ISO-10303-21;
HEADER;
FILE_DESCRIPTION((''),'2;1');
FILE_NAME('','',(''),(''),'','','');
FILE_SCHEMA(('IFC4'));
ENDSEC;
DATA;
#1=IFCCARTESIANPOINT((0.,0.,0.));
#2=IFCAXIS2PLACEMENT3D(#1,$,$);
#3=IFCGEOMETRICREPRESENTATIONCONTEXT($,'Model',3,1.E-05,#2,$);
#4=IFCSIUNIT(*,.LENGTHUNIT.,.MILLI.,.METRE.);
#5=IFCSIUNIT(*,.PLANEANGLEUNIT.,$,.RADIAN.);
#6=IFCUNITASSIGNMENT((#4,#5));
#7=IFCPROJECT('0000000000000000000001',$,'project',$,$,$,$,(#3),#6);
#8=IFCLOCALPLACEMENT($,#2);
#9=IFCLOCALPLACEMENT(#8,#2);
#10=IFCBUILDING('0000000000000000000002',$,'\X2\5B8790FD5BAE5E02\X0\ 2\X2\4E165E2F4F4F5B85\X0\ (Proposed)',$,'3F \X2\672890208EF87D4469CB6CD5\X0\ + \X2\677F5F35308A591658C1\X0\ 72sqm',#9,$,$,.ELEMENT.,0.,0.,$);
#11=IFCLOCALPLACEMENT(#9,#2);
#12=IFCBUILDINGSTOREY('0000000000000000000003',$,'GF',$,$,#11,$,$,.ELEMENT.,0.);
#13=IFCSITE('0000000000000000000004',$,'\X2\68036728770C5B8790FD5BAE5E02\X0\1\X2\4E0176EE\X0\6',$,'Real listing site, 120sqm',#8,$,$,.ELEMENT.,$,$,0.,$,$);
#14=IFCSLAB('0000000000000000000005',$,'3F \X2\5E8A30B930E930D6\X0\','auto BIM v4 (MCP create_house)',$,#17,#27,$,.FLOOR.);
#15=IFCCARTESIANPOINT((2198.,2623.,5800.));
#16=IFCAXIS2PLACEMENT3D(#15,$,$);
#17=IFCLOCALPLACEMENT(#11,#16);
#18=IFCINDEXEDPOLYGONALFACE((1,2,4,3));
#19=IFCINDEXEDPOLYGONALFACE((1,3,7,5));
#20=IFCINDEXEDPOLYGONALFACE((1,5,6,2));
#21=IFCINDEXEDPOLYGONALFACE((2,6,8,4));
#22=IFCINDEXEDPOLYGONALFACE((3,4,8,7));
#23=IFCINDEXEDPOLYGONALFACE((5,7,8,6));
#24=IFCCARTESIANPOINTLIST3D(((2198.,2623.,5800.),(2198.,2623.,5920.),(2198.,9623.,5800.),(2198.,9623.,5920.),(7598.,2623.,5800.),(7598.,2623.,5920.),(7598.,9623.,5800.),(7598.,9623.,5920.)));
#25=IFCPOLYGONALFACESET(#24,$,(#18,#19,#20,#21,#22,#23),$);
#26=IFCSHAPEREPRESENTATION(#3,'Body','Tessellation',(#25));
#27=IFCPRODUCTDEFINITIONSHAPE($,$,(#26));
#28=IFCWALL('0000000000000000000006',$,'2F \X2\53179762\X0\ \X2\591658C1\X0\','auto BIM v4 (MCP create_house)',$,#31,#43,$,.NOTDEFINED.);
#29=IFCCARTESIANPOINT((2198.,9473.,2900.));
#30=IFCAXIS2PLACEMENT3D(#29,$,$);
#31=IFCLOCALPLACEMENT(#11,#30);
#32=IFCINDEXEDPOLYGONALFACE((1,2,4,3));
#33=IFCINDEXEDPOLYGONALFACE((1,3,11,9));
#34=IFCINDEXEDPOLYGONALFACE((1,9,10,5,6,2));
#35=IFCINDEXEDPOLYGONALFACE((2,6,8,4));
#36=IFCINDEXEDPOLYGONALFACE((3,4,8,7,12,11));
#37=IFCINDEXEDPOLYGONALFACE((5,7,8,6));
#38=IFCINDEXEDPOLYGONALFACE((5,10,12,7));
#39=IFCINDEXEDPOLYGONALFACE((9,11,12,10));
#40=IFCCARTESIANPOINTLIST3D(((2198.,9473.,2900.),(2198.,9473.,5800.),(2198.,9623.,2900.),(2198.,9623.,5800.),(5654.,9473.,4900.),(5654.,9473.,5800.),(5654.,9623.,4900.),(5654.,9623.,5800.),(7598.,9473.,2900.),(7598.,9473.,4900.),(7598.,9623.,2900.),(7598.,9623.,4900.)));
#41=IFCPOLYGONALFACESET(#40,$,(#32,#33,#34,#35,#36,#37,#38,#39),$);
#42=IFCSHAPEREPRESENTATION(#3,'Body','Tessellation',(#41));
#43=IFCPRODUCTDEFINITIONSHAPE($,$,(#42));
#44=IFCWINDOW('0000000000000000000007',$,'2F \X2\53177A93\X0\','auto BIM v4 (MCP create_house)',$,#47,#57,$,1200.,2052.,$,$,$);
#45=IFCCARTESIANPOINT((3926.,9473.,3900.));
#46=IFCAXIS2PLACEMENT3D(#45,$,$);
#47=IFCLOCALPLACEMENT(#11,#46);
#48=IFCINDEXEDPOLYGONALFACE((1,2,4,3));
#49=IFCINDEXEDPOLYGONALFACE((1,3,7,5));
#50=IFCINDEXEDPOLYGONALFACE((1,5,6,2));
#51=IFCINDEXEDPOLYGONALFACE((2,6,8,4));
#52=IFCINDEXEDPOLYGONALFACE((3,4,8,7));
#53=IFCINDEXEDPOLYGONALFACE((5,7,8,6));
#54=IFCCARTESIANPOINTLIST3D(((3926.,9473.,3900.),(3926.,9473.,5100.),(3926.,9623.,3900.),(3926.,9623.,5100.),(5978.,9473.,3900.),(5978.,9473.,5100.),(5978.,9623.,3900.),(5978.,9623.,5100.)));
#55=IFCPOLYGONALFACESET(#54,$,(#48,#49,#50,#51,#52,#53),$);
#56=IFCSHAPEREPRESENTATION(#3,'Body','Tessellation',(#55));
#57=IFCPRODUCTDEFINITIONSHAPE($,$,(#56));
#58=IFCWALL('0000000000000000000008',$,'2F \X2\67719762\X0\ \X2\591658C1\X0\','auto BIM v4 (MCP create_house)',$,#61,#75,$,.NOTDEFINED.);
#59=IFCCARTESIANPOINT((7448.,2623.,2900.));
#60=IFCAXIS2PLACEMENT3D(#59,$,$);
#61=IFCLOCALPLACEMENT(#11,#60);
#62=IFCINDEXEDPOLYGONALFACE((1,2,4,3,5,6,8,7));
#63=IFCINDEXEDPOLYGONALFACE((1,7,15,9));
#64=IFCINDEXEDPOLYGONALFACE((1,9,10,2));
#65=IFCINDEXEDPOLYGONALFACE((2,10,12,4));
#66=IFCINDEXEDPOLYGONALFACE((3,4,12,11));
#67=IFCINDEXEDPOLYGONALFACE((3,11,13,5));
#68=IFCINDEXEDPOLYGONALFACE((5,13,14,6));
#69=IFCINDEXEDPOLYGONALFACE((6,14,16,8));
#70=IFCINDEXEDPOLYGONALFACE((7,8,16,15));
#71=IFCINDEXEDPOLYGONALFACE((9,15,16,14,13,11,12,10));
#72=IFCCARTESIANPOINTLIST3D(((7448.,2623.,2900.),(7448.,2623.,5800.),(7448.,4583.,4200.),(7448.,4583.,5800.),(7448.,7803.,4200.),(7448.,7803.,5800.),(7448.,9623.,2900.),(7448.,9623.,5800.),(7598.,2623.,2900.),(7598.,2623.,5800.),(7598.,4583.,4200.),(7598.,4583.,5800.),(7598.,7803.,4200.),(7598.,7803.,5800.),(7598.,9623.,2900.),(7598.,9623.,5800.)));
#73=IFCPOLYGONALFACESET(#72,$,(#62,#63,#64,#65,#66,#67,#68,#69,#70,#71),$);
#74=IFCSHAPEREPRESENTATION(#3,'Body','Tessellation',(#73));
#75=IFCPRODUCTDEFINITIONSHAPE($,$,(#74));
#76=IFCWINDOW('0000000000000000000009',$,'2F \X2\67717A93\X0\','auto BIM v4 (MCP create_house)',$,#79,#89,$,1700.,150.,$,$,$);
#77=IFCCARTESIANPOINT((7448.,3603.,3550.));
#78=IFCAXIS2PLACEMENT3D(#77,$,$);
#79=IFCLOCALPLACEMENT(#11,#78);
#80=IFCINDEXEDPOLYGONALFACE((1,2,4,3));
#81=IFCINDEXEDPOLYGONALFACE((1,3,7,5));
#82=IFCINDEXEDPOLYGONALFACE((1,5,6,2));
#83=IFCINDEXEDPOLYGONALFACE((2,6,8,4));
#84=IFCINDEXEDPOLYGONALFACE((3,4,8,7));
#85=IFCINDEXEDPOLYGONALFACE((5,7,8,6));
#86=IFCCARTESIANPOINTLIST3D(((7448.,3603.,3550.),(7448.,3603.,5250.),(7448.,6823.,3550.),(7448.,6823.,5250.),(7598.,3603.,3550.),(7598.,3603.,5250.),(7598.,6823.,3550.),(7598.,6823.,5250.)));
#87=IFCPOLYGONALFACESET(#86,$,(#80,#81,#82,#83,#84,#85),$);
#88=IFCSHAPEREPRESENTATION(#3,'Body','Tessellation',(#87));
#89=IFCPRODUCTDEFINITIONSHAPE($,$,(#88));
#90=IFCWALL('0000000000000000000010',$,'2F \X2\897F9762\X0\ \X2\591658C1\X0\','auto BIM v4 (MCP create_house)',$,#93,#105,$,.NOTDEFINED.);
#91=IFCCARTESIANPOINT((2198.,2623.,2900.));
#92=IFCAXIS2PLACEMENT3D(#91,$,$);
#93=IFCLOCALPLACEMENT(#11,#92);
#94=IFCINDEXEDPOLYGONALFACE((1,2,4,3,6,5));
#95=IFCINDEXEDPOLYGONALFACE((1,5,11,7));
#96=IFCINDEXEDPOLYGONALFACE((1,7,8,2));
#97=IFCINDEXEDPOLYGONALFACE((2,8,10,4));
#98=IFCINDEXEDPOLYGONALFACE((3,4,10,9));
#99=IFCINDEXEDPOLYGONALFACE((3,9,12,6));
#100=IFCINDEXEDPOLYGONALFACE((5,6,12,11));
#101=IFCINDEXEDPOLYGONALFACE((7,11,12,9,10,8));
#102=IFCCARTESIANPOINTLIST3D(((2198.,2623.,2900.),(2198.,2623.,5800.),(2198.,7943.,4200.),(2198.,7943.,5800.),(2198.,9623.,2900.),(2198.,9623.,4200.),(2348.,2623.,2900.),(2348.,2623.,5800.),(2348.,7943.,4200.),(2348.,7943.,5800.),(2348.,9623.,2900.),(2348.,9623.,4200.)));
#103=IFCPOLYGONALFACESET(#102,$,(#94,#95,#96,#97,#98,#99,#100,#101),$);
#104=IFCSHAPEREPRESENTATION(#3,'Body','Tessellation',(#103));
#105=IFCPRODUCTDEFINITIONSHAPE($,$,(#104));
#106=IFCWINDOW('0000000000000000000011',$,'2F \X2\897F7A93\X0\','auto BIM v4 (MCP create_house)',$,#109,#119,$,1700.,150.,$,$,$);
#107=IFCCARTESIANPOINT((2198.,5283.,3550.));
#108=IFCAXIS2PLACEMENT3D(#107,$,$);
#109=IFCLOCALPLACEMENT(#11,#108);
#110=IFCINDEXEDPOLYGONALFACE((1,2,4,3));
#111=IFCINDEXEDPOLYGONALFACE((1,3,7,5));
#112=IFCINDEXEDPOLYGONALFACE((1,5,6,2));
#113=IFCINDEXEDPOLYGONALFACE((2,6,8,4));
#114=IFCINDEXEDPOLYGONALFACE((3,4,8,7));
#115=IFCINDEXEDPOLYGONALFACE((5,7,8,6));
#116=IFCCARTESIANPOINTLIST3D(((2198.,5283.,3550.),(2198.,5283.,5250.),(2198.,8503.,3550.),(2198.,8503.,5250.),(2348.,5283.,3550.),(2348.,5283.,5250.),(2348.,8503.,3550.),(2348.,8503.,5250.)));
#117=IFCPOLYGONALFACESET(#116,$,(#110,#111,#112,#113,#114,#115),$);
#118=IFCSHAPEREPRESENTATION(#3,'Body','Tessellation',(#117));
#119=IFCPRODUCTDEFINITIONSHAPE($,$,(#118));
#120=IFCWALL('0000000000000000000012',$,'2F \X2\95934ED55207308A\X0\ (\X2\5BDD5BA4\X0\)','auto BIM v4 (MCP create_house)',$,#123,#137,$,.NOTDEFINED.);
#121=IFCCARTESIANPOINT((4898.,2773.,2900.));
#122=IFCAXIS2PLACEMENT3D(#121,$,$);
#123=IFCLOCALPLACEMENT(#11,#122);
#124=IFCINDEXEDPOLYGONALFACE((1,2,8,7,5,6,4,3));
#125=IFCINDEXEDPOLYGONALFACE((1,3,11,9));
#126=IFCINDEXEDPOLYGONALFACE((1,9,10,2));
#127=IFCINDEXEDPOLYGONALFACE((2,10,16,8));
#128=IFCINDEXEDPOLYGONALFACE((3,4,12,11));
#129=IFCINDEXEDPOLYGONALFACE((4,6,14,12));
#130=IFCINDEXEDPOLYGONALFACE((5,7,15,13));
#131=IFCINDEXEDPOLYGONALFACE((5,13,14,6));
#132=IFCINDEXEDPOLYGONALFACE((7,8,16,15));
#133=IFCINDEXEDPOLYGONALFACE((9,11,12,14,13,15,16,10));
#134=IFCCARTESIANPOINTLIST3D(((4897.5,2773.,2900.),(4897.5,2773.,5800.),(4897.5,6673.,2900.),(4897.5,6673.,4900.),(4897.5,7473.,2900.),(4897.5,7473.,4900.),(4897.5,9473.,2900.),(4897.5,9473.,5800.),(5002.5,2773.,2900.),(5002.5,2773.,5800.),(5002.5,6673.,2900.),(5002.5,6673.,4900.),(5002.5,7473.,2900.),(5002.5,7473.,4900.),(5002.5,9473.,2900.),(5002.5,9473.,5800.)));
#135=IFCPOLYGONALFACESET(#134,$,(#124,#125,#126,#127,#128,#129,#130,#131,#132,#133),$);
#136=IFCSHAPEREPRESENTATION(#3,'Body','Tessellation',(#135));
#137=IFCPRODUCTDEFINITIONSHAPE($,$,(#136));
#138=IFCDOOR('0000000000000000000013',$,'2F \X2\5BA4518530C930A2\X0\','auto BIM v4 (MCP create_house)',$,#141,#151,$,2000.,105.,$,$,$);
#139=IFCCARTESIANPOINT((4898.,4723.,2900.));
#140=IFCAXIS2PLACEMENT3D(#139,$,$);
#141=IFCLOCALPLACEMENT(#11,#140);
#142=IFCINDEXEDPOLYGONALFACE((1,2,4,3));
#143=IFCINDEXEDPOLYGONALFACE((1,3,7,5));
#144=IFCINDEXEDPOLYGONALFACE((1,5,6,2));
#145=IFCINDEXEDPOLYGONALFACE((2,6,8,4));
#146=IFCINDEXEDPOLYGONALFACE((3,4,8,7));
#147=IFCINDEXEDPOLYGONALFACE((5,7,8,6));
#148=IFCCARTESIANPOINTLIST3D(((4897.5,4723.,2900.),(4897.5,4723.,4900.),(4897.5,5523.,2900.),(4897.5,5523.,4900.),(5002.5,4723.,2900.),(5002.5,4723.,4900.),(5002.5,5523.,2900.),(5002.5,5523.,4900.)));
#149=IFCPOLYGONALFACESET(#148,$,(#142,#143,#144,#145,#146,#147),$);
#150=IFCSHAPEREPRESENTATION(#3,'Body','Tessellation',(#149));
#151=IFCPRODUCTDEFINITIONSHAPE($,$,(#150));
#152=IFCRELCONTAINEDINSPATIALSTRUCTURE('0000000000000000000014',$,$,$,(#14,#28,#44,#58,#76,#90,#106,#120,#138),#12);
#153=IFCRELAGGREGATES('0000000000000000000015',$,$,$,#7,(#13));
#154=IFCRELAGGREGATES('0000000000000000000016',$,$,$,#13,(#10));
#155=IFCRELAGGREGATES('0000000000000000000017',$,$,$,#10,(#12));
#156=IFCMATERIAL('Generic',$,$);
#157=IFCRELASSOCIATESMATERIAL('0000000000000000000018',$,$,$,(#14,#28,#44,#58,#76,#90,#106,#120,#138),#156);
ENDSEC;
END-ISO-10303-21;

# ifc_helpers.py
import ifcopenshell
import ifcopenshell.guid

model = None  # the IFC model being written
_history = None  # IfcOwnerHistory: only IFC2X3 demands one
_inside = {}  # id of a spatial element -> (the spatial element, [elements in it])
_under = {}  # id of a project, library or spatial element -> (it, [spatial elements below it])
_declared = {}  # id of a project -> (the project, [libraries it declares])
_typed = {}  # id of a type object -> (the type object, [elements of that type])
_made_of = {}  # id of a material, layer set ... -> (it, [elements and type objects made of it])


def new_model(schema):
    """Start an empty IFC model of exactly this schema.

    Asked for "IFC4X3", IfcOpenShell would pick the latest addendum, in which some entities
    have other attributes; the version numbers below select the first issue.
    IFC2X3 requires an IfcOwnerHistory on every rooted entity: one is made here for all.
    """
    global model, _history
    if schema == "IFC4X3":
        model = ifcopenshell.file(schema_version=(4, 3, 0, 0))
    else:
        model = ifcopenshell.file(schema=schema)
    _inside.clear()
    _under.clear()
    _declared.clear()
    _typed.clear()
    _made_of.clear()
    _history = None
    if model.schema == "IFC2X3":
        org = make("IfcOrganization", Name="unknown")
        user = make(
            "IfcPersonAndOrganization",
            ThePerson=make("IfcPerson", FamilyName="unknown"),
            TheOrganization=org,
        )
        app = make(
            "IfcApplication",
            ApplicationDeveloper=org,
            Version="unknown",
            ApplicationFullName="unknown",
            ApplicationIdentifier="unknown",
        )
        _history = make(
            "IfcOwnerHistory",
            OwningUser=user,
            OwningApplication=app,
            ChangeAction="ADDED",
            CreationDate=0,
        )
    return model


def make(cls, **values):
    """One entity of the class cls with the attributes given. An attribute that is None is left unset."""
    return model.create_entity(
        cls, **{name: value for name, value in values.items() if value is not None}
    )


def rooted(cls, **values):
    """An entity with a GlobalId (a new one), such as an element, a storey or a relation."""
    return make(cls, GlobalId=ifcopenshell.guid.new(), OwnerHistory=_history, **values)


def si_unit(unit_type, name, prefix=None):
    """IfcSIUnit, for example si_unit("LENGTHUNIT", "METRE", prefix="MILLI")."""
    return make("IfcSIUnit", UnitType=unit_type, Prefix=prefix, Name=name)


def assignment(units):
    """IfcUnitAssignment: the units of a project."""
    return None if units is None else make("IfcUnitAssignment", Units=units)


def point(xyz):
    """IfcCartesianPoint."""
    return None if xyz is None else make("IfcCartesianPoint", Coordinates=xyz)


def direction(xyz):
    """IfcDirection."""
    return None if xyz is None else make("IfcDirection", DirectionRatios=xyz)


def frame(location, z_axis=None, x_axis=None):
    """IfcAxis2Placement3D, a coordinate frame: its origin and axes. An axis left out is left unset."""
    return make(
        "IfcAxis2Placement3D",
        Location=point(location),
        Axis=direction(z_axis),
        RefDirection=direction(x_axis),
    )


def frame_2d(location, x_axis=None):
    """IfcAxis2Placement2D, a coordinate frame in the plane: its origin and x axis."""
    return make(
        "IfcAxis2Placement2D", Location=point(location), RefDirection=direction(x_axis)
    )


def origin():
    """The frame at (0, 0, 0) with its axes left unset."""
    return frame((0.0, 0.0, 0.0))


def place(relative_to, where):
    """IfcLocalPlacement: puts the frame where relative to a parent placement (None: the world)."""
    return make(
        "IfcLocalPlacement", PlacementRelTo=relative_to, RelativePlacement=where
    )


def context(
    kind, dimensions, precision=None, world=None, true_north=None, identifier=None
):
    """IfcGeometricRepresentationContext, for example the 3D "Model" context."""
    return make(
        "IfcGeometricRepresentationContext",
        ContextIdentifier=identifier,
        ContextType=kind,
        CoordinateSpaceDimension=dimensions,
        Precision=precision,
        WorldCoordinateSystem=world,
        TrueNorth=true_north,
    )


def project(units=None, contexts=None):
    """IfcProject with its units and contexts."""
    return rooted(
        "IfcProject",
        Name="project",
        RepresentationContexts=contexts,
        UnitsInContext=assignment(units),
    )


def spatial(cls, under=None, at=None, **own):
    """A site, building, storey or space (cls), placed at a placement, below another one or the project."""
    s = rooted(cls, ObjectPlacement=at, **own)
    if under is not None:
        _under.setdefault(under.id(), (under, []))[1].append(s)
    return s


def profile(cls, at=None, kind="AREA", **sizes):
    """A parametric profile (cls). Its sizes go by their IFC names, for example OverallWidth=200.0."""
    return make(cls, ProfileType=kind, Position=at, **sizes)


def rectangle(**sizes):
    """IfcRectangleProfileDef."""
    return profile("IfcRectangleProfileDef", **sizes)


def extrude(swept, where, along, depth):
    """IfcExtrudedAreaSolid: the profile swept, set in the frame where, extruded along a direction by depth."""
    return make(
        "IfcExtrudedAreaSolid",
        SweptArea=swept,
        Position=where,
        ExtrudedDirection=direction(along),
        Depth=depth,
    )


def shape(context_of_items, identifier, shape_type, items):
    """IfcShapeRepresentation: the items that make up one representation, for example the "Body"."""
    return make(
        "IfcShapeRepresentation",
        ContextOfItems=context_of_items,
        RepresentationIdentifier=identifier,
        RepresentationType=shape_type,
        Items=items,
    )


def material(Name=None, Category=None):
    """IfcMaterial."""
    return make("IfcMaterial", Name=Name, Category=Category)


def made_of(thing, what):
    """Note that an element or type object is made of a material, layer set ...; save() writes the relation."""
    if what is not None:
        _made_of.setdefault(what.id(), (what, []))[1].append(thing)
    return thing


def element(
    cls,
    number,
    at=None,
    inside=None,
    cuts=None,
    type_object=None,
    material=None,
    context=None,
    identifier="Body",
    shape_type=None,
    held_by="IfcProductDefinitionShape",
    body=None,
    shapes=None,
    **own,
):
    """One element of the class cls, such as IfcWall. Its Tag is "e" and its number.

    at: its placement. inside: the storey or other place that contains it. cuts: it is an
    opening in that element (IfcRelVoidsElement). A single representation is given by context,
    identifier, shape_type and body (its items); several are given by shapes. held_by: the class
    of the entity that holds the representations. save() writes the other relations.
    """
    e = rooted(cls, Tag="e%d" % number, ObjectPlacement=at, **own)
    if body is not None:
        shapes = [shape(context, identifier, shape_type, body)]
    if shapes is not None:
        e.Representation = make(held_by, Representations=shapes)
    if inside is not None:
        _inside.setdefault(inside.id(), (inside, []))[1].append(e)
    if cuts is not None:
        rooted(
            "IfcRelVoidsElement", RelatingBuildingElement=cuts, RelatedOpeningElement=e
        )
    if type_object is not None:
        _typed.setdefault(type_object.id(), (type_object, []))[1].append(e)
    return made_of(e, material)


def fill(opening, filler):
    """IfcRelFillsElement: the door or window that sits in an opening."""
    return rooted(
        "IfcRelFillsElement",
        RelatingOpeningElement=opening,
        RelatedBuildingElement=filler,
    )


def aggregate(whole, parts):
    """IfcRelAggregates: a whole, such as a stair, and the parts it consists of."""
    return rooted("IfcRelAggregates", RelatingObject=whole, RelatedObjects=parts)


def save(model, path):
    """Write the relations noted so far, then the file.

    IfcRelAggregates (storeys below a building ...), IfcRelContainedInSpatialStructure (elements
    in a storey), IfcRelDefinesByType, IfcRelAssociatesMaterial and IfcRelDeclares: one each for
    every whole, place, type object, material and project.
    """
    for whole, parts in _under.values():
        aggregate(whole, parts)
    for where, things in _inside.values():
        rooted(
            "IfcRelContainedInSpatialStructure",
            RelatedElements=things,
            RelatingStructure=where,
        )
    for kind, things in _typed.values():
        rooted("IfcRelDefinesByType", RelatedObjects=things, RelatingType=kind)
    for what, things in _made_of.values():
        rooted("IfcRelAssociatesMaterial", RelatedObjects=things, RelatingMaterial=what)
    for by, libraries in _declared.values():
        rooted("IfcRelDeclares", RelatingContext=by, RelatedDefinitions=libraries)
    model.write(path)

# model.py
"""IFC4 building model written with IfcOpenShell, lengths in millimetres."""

from ifc_helpers import new_model, si_unit, frame, frame_2d, origin, place, context, project, spatial, rectangle, extrude, material, element, fill, save


model = new_model("IFC4")

# Units and contexts
model_context = context("Model", 3, precision=1e-05, world=origin())
ifc_project = project(units=[si_unit("LENGTHUNIT", "METRE", prefix="MILLI"), si_unit("PLANEANGLEUNIT", "RADIAN")], contexts=[model_context])

# Site, building, storey
site_placement = place(None, origin())
site = spatial("IfcSite", under=ifc_project, at=site_placement, Name="栃木県宇都宮市1丁目6", ObjectType="Real listing site, 120sqm", CompositionType="ELEMENT", RefElevation=0.0)
building_placement = place(site_placement, origin())
building = spatial("IfcBuilding", under=site, at=building_placement, Name="宇都宮市 2世帯住宅 (Proposed)", ObjectType="3F 木造軸組構法 + 板張り外壁 72sqm", CompositionType="ELEMENT", ElevationOfRefHeight=0.0, ElevationOfTerrain=0.0)
storey_placement = place(building_placement, origin())
storey = spatial("IfcBuildingStorey", under=building, at=storey_placement, Name="GF", CompositionType="ELEMENT", Elevation=0.0)

# Slab
ifc_material = material(Name="Generic")
slab_placement = place(storey_placement, frame((2198.0, 2623.0, 5800.0)))
element("IfcSlab", 1, at=slab_placement, inside=storey, material=ifc_material, Name="3F 床スラブ", Description="auto BIM v4 (MCP create_house)", PredefinedType="FLOOR", context=model_context, shape_type="SweptSolid", body=[
    extrude(rectangle(XDim=5400.0, YDim=7000.0, at=frame_2d((2700.0, 3500.0))), frame((2198.0, 2623.0, 5800.0)), (0.0, 0.0, 1.0), 120.0),
])

# Walls, openings, windows
wall_1_placement = place(storey_placement, frame((2198.0, 9473.0, 2900.0)))
wall_1 = element("IfcWall", 2, at=wall_1_placement, inside=storey, material=ifc_material, Name="2F 北面 外壁", Description="auto BIM v4 (MCP create_house)", PredefinedType="NOTDEFINED", context=model_context, shape_type="SweptSolid", body=[
    extrude(rectangle(XDim=5400.0, YDim=150.0, at=frame_2d((2700.0, 75.0))), frame((2198.0, 9473.0, 2900.0)), (0.0, 0.0, 1.0), 2900.0),
])
opening_1_placement = place(storey_placement, frame((3926.0, 9473.0, 3900.0)))
opening_1 = element("IfcOpeningElement", 3, at=opening_1_placement, cuts=wall_1, PredefinedType="NOTDEFINED", context=model_context, shape_type="SweptSolid", body=[
    extrude(rectangle(XDim=2052.0, YDim=150.0, at=frame_2d((1026.0, 75.0))), frame((3926.0, 9473.0, 3900.0)), (0.0, 0.0, 1.0), 1200.0),
])
window_1_placement = place(storey_placement, frame((3926.0, 9473.0, 3900.0)))
window_1 = element("IfcWindow", 4, at=window_1_placement, inside=storey, material=ifc_material, Name="2F 北窓", Description="auto BIM v4 (MCP create_house)", OverallHeight=1200.0, OverallWidth=2052.0, context=model_context, shape_type="SweptSolid", body=[
    extrude(rectangle(XDim=2052.0, YDim=150.0, at=frame_2d((1026.0, 75.0))), frame((3926.0, 9473.0, 3900.0)), (0.0, 0.0, 1.0), 1200.0),
])
fill(opening_1, window_1)
wall_2_placement = place(storey_placement, frame((7448.0, 2623.0, 2900.0)))
wall_2 = element("IfcWall", 5, at=wall_2_placement, inside=storey, material=ifc_material, Name="2F 東面 外壁", Description="auto BIM v4 (MCP create_house)", PredefinedType="NOTDEFINED", context=model_context, shape_type="SweptSolid", body=[
    extrude(rectangle(XDim=150.0, YDim=7000.0, at=frame_2d((75.0, 3500.0))), frame((7448.0, 2623.0, 2900.0)), (0.0, 0.0, 1.0), 2900.0),
])
opening_2_placement = place(storey_placement, frame((7448.0, 3603.0, 3550.0)))
opening_2 = element("IfcOpeningElement", 6, at=opening_2_placement, cuts=wall_2, PredefinedType="NOTDEFINED", context=model_context, shape_type="SweptSolid", body=[
    extrude(rectangle(XDim=150.0, YDim=3220.0, at=frame_2d((75.0, 1610.0))), frame((7448.0, 3603.0, 3550.0)), (0.0, 0.0, 1.0), 1700.0),
])
window_2_placement = place(storey_placement, frame((7448.0, 3603.0, 3550.0)))
window_2 = element("IfcWindow", 7, at=window_2_placement, inside=storey, material=ifc_material, Name="2F 東窓", Description="auto BIM v4 (MCP create_house)", OverallHeight=1700.0, OverallWidth=150.0, context=model_context, shape_type="SweptSolid", body=[
    extrude(rectangle(XDim=150.0, YDim=3220.0, at=frame_2d((75.0, 1610.0))), frame((7448.0, 3603.0, 3550.0)), (0.0, 0.0, 1.0), 1700.0),
])
fill(opening_2, window_2)
wall_3_placement = place(storey_placement, frame((2198.0, 2623.0, 2900.0)))
wall_3 = element("IfcWall", 8, at=wall_3_placement, inside=storey, material=ifc_material, Name="2F 西面 外壁", Description="auto BIM v4 (MCP create_house)", PredefinedType="NOTDEFINED", context=model_context, shape_type="SweptSolid", body=[
    extrude(rectangle(XDim=150.0, YDim=7000.0, at=frame_2d((75.0, 3500.0))), frame((2198.0, 2623.0, 2900.0)), (0.0, 0.0, 1.0), 2900.0),
])
opening_3_placement = place(storey_placement, frame((2198.0, 5283.0, 3550.0)))
opening_3 = element("IfcOpeningElement", 9, at=opening_3_placement, cuts=wall_3, PredefinedType="NOTDEFINED", context=model_context, shape_type="SweptSolid", body=[
    extrude(rectangle(XDim=150.0, YDim=3220.0, at=frame_2d((75.0, 1610.0))), frame((2198.0, 5283.0, 3550.0)), (0.0, 0.0, 1.0), 1700.0),
])
window_3_placement = place(storey_placement, frame((2198.0, 5283.0, 3550.0)))
window_3 = element("IfcWindow", 10, at=window_3_placement, inside=storey, material=ifc_material, Name="2F 西窓", Description="auto BIM v4 (MCP create_house)", OverallHeight=1700.0, OverallWidth=150.0, context=model_context, shape_type="SweptSolid", body=[
    extrude(rectangle(XDim=150.0, YDim=3220.0, at=frame_2d((75.0, 1610.0))), frame((2198.0, 5283.0, 3550.0)), (0.0, 0.0, 1.0), 1700.0),
])
fill(opening_3, window_3)

# Wall, opening, door
wall_4_placement = place(storey_placement, frame((4898.0, 2773.0, 2900.0)))
wall_4 = element("IfcWall", 11, at=wall_4_placement, inside=storey, material=ifc_material, Name="2F 間仕切り (寝室)", Description="auto BIM v4 (MCP create_house)", PredefinedType="NOTDEFINED", context=model_context, shape_type="SweptSolid", body=[
    extrude(rectangle(XDim=105.0, YDim=6700.0, at=frame_2d((52.0, 3350.0))), frame((4898.0, 2773.0, 2900.0)), (0.0, 0.0, 1.0), 2900.0),
])
opening_4_placement = place(storey_placement, frame((4898.0, 4723.0, 2900.0)))
opening_4 = element("IfcOpeningElement", 12, at=opening_4_placement, cuts=wall_4, PredefinedType="NOTDEFINED", context=model_context, shape_type="SweptSolid", body=[
    extrude(rectangle(XDim=105.0, YDim=800.0, at=frame_2d((52.0, 400.0))), frame((4898.0, 4723.0, 2900.0)), (0.0, 0.0, 1.0), 2000.0),
])
door_1_placement = place(storey_placement, frame((4898.0, 4723.0, 2900.0)))
door_1 = element("IfcDoor", 13, at=door_1_placement, inside=storey, material=ifc_material, Name="2F 室内ドア", Description="auto BIM v4 (MCP create_house)", OverallHeight=2000.0, OverallWidth=105.0, context=model_context, shape_type="SweptSolid", body=[
    extrude(rectangle(XDim=105.0, YDim=800.0, at=frame_2d((52.0, 400.0))), frame((4898.0, 4723.0, 2900.0)), (0.0, 0.0, 1.0), 2000.0),
])
fill(opening_4, door_1)

save(model, "model.ifc")
